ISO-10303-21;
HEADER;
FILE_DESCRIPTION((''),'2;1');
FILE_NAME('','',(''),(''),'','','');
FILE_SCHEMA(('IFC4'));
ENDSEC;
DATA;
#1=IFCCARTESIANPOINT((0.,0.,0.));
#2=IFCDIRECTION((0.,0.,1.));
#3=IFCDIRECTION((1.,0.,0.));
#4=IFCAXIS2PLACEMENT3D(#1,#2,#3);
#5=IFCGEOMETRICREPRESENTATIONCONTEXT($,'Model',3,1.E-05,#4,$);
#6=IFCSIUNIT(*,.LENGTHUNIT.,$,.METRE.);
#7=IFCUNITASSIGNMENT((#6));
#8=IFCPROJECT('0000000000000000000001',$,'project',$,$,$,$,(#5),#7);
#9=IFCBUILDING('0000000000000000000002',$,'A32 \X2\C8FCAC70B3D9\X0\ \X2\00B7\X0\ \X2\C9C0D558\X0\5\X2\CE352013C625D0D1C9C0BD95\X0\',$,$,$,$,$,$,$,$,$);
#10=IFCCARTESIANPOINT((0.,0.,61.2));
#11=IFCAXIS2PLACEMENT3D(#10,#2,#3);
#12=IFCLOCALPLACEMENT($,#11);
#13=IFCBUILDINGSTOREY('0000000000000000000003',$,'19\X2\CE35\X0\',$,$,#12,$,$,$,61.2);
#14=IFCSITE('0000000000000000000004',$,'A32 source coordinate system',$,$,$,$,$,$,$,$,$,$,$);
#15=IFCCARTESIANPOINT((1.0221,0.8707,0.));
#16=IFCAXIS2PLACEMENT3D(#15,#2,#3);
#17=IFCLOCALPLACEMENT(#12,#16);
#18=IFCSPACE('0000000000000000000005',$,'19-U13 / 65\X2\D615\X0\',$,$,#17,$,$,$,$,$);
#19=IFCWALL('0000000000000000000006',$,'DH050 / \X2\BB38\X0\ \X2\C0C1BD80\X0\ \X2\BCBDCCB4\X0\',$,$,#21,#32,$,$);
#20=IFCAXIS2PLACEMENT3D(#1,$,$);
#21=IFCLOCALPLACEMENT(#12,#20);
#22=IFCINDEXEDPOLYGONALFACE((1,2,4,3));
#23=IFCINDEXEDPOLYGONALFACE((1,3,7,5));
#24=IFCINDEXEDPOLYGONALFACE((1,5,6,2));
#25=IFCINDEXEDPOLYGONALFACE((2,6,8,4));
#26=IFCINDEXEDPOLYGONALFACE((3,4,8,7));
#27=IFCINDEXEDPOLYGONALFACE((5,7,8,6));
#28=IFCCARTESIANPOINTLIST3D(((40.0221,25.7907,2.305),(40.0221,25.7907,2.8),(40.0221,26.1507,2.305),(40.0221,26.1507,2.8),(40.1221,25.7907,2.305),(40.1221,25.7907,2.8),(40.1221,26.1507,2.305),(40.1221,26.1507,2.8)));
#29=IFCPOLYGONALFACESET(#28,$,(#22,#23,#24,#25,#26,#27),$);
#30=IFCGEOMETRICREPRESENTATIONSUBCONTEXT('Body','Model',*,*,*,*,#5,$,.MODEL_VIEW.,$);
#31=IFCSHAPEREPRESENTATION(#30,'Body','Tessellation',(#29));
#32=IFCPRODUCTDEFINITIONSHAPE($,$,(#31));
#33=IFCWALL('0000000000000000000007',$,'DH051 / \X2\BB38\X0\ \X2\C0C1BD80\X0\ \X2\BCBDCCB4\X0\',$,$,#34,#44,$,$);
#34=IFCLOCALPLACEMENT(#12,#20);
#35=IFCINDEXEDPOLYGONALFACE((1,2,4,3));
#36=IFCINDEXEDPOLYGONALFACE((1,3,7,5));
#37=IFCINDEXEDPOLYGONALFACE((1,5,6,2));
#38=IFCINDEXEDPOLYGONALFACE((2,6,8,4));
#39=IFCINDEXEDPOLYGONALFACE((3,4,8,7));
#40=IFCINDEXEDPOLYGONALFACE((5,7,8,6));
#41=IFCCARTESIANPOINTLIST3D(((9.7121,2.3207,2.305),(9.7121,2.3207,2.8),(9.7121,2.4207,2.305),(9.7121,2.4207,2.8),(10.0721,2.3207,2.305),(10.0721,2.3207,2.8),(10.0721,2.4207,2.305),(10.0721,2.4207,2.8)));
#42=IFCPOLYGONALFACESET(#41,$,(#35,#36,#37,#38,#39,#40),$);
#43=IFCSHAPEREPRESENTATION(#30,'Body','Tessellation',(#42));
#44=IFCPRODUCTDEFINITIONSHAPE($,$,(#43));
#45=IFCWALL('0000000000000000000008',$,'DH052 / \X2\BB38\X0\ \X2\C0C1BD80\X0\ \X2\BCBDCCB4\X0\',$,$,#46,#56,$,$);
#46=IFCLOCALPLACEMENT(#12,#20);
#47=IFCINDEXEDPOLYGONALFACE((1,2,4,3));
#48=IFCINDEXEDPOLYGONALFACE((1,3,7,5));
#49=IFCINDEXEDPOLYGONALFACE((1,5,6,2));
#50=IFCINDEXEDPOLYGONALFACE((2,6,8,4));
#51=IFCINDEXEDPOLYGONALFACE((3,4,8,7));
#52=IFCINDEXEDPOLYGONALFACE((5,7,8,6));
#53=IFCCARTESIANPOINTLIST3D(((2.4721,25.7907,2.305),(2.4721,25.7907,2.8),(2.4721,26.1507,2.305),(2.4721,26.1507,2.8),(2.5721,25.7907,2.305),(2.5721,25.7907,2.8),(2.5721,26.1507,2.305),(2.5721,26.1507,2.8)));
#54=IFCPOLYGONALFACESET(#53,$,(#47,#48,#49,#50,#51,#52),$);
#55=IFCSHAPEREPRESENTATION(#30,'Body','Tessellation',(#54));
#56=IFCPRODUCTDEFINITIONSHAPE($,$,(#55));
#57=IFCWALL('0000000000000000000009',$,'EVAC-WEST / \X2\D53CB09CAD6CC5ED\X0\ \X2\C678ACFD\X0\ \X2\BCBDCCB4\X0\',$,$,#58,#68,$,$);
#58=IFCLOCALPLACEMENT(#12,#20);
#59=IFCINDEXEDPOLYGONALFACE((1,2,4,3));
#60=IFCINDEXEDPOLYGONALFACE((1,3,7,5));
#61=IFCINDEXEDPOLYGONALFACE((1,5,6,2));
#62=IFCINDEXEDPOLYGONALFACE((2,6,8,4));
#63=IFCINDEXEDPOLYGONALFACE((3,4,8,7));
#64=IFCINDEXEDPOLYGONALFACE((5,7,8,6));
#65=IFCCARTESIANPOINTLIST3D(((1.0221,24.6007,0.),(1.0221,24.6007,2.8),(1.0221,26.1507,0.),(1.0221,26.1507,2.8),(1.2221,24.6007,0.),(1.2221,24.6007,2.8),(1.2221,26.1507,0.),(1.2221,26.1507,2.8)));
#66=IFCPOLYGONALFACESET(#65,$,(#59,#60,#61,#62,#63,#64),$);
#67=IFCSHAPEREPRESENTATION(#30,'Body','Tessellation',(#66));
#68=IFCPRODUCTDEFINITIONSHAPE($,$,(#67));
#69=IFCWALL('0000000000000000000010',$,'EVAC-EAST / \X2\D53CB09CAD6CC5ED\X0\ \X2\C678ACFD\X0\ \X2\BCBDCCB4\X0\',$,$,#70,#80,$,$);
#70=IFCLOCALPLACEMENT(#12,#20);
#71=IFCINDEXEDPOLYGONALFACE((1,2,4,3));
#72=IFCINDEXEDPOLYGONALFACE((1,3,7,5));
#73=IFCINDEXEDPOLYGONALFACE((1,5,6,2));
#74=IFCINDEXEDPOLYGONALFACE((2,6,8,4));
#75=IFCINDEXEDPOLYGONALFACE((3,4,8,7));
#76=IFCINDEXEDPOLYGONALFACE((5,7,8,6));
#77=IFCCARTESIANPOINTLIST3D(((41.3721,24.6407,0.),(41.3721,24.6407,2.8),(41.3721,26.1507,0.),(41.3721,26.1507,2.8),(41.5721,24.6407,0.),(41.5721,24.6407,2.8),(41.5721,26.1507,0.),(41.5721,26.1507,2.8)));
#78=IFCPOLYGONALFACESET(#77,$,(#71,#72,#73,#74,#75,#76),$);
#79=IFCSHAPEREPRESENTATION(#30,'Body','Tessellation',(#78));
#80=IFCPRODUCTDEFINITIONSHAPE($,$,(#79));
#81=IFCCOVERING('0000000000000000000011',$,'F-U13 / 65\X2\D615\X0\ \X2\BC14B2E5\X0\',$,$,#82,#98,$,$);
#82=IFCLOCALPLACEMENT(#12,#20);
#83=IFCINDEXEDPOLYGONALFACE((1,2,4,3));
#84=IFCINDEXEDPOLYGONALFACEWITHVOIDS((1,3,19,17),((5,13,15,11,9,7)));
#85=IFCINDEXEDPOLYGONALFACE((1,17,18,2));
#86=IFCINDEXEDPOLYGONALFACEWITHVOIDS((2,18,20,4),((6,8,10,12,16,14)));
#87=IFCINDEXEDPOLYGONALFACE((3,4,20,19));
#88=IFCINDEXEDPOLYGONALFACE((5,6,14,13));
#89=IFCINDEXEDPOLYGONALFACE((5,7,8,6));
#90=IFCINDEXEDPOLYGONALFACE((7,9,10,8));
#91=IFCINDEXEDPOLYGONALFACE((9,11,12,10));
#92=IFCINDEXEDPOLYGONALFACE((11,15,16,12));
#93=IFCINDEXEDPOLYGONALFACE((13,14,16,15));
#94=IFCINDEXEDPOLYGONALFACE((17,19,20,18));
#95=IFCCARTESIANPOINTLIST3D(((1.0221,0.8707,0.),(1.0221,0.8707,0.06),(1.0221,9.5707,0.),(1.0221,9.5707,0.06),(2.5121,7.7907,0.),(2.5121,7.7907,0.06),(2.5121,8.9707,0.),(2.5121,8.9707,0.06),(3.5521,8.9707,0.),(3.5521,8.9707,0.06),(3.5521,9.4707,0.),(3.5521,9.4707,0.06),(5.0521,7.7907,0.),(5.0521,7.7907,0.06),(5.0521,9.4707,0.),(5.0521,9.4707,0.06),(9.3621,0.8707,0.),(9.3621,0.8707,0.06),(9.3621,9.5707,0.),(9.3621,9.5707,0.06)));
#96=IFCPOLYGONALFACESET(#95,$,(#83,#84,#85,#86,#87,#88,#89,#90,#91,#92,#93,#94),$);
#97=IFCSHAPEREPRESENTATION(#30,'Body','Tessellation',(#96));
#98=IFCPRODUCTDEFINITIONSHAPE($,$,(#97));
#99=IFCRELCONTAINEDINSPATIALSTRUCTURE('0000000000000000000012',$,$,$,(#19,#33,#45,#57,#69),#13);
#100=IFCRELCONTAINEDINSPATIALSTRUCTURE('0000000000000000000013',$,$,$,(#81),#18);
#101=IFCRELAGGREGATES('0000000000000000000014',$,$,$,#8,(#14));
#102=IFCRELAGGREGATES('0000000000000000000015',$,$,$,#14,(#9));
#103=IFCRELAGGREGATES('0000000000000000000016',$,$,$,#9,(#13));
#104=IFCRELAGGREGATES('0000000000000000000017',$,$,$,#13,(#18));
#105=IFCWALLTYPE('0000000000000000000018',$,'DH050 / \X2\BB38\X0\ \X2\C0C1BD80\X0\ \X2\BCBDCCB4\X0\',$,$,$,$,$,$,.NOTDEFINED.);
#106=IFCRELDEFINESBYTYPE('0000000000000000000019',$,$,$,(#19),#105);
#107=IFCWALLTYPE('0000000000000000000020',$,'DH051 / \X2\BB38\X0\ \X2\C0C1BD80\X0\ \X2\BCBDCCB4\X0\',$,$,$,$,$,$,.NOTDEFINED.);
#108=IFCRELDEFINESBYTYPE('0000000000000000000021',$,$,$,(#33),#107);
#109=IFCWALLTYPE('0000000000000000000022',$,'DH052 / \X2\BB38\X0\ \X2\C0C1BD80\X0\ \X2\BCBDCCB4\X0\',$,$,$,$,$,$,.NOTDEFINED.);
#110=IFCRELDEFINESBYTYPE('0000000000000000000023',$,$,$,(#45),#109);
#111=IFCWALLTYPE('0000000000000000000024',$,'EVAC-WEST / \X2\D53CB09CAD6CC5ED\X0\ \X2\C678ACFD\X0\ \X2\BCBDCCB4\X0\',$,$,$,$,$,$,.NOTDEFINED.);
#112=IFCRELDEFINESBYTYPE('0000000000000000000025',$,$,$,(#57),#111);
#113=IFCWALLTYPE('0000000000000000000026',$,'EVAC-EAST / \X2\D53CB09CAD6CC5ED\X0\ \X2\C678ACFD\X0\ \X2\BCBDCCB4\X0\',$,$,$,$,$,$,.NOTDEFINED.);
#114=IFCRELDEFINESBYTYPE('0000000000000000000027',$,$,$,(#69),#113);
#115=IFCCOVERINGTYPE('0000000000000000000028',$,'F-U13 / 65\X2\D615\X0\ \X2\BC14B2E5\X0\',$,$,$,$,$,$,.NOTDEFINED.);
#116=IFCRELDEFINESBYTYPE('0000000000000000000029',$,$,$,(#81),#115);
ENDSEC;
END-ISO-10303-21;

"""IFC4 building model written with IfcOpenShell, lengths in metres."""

from ifc_helpers import new_model, si_unit, frame, origin, origin_with_axes, place, context, subcontext, project, spatial, polyline, outline, extrude, source, transform, mapped, type_object, type_shapes, element, save


model = new_model("IFC4")

# Units and contexts
model_context = context("Model", 3, precision=1e-05, world=origin_with_axes())
body_context = subcontext(model_context, "Body", "Model", "MODEL_VIEW")
ifc_project = project(units=[si_unit("LENGTHUNIT", "METRE")], contexts=[model_context])

# Site, building, storey
site = spatial("IfcSite", under=ifc_project, Name="A32 source coordinate system")
building = spatial("IfcBuilding", under=site, Name="A32 주거동 · 지하5층–옥탑지붕")
storey_placement = place(None, frame((0.0, 0.0, 61.2), z_axis=(0.0, 0.0, 1.0), x_axis=(1.0, 0.0, 0.0)))
storey = spatial("IfcBuildingStorey", under=building, at=storey_placement, Name="19층", Elevation=61.2)

# Walls
wall_type_1 = type_object("IfcWallType", Name="DH050 / 문 상부 벽체", PredefinedType="NOTDEFINED")
shared_shape_1 = source(origin(), body_context, "Body", "SweptSolid", [
    extrude(outline(polyline([(40.0221, 25.7907), (40.0221, 26.1507), (40.1221, 26.1507), (40.1221, 25.7907), (40.0221, 25.7907)])), frame((0.0, 0.0, 2.305)), (0.0, 0.0, 1.0), 0.495),
])
type_shapes(wall_type_1, [shared_shape_1])
wall_1_placement = place(storey_placement, origin_with_axes())
element("IfcWall", 1, at=wall_1_placement, inside=storey, type_object=wall_type_1, Name="DH050 / 문 상부 벽체", context=body_context, shape_type="MappedRepresentation", body=[
    mapped(shared_shape_1, transform((0.0, 0.0, 0.0), scale=1.0)),
])
wall_type_2 = type_object("IfcWallType", Name="DH051 / 문 상부 벽체", PredefinedType="NOTDEFINED")
shared_shape_2 = source(origin(), body_context, "Body", "SweptSolid", [
    extrude(outline(polyline([(10.0721, 2.3207), (9.7121, 2.3207), (9.7121, 2.4207), (10.0721, 2.4207), (10.0721, 2.3207)])), frame((0.0, 0.0, 2.305)), (0.0, 0.0, 1.0), 0.495),
])
type_shapes(wall_type_2, [shared_shape_2])
wall_2_placement = place(storey_placement, origin_with_axes())
element("IfcWall", 2, at=wall_2_placement, inside=storey, type_object=wall_type_2, Name="DH051 / 문 상부 벽체", context=body_context, shape_type="MappedRepresentation", body=[
    mapped(shared_shape_2, transform((0.0, 0.0, 0.0), scale=1.0)),
])
wall_type_3 = type_object("IfcWallType", Name="DH052 / 문 상부 벽체", PredefinedType="NOTDEFINED")
shared_shape_3 = source(origin(), body_context, "Body", "SweptSolid", [
    extrude(outline(polyline([(2.5721, 25.7907), (2.4721, 25.7907), (2.4721, 26.1507), (2.5721, 26.1507), (2.5721, 25.7907)])), frame((0.0, 0.0, 2.305)), (0.0, 0.0, 1.0), 0.495),
])
type_shapes(wall_type_3, [shared_shape_3])
wall_3_placement = place(storey_placement, origin_with_axes())
element("IfcWall", 3, at=wall_3_placement, inside=storey, type_object=wall_type_3, Name="DH052 / 문 상부 벽체", context=body_context, shape_type="MappedRepresentation", body=[
    mapped(shared_shape_3, transform((0.0, 0.0, 0.0), scale=1.0)),
])
wall_type_4 = type_object("IfcWallType", Name="EVAC-WEST / 피난구역 외곽 벽체", PredefinedType="NOTDEFINED")
shared_shape_4 = source(origin(), body_context, "Body", "SweptSolid", [
    extrude(outline(polyline([(1.2221, 24.6007), (1.0221, 24.6007), (1.0221, 26.1507), (1.2221, 26.1507), (1.2221, 24.6007)])), origin(), (0.0, 0.0, 1.0), 2.8),
])
type_shapes(wall_type_4, [shared_shape_4])
wall_4_placement = place(storey_placement, origin_with_axes())
element("IfcWall", 4, at=wall_4_placement, inside=storey, type_object=wall_type_4, Name="EVAC-WEST / 피난구역 외곽 벽체", context=body_context, shape_type="MappedRepresentation", body=[
    mapped(shared_shape_4, transform((0.0, 0.0, 0.0), scale=1.0)),
])
wall_type_5 = type_object("IfcWallType", Name="EVAC-EAST / 피난구역 외곽 벽체", PredefinedType="NOTDEFINED")
shared_shape_5 = source(origin(), body_context, "Body", "SweptSolid", [
    extrude(outline(polyline([(41.5721, 26.1507), (41.5721, 24.6407), (41.3721, 24.6407), (41.3721, 26.1507), (41.5721, 26.1507)])), origin(), (0.0, 0.0, 1.0), 2.8),
])
type_shapes(wall_type_5, [shared_shape_5])
wall_5_placement = place(storey_placement, origin_with_axes())
element("IfcWall", 5, at=wall_5_placement, inside=storey, type_object=wall_type_5, Name="EVAC-EAST / 피난구역 외곽 벽체", context=body_context, shape_type="MappedRepresentation", body=[
    mapped(shared_shape_5, transform((0.0, 0.0, 0.0), scale=1.0)),
])

# Shared definitions
space_placement = place(storey_placement, frame((1.0221, 0.8707, 0.0), z_axis=(0.0, 0.0, 1.0), x_axis=(1.0, 0.0, 0.0)))
space = spatial("IfcSpace", under=storey, at=space_placement, Name="19-U13 / 65형")

# Covering
covering_type_1 = type_object("IfcCoveringType", Name="F-U13 / 65형 바닥", PredefinedType="NOTDEFINED")
shared_shape_6 = source(origin(), body_context, "Body", "SweptSolid", [
    extrude(outline(polyline([(0.0, 0.0), (0.0, 8.7), (8.34, 8.7), (8.34, 0.0), (0.0, 0.0)]), holes=[polyline([(2.53, 8.1), (1.49, 8.1), (1.49, 6.92), (4.03, 6.92), (4.03, 8.6), (2.53, 8.6), (2.53, 8.1)])]), origin(), (0.0, 0.0, 1.0), 0.06),
])
type_shapes(covering_type_1, [shared_shape_6])
covering_1_placement = place(space_placement, origin_with_axes())
element("IfcCovering", 6, at=covering_1_placement, inside=space, type_object=covering_type_1, Name="F-U13 / 65형 바닥", context=body_context, shape_type="MappedRepresentation", body=[
    mapped(shared_shape_6, transform((0.0, 0.0, 0.0), scale=1.0)),
])

save(model, "model.ifc")
